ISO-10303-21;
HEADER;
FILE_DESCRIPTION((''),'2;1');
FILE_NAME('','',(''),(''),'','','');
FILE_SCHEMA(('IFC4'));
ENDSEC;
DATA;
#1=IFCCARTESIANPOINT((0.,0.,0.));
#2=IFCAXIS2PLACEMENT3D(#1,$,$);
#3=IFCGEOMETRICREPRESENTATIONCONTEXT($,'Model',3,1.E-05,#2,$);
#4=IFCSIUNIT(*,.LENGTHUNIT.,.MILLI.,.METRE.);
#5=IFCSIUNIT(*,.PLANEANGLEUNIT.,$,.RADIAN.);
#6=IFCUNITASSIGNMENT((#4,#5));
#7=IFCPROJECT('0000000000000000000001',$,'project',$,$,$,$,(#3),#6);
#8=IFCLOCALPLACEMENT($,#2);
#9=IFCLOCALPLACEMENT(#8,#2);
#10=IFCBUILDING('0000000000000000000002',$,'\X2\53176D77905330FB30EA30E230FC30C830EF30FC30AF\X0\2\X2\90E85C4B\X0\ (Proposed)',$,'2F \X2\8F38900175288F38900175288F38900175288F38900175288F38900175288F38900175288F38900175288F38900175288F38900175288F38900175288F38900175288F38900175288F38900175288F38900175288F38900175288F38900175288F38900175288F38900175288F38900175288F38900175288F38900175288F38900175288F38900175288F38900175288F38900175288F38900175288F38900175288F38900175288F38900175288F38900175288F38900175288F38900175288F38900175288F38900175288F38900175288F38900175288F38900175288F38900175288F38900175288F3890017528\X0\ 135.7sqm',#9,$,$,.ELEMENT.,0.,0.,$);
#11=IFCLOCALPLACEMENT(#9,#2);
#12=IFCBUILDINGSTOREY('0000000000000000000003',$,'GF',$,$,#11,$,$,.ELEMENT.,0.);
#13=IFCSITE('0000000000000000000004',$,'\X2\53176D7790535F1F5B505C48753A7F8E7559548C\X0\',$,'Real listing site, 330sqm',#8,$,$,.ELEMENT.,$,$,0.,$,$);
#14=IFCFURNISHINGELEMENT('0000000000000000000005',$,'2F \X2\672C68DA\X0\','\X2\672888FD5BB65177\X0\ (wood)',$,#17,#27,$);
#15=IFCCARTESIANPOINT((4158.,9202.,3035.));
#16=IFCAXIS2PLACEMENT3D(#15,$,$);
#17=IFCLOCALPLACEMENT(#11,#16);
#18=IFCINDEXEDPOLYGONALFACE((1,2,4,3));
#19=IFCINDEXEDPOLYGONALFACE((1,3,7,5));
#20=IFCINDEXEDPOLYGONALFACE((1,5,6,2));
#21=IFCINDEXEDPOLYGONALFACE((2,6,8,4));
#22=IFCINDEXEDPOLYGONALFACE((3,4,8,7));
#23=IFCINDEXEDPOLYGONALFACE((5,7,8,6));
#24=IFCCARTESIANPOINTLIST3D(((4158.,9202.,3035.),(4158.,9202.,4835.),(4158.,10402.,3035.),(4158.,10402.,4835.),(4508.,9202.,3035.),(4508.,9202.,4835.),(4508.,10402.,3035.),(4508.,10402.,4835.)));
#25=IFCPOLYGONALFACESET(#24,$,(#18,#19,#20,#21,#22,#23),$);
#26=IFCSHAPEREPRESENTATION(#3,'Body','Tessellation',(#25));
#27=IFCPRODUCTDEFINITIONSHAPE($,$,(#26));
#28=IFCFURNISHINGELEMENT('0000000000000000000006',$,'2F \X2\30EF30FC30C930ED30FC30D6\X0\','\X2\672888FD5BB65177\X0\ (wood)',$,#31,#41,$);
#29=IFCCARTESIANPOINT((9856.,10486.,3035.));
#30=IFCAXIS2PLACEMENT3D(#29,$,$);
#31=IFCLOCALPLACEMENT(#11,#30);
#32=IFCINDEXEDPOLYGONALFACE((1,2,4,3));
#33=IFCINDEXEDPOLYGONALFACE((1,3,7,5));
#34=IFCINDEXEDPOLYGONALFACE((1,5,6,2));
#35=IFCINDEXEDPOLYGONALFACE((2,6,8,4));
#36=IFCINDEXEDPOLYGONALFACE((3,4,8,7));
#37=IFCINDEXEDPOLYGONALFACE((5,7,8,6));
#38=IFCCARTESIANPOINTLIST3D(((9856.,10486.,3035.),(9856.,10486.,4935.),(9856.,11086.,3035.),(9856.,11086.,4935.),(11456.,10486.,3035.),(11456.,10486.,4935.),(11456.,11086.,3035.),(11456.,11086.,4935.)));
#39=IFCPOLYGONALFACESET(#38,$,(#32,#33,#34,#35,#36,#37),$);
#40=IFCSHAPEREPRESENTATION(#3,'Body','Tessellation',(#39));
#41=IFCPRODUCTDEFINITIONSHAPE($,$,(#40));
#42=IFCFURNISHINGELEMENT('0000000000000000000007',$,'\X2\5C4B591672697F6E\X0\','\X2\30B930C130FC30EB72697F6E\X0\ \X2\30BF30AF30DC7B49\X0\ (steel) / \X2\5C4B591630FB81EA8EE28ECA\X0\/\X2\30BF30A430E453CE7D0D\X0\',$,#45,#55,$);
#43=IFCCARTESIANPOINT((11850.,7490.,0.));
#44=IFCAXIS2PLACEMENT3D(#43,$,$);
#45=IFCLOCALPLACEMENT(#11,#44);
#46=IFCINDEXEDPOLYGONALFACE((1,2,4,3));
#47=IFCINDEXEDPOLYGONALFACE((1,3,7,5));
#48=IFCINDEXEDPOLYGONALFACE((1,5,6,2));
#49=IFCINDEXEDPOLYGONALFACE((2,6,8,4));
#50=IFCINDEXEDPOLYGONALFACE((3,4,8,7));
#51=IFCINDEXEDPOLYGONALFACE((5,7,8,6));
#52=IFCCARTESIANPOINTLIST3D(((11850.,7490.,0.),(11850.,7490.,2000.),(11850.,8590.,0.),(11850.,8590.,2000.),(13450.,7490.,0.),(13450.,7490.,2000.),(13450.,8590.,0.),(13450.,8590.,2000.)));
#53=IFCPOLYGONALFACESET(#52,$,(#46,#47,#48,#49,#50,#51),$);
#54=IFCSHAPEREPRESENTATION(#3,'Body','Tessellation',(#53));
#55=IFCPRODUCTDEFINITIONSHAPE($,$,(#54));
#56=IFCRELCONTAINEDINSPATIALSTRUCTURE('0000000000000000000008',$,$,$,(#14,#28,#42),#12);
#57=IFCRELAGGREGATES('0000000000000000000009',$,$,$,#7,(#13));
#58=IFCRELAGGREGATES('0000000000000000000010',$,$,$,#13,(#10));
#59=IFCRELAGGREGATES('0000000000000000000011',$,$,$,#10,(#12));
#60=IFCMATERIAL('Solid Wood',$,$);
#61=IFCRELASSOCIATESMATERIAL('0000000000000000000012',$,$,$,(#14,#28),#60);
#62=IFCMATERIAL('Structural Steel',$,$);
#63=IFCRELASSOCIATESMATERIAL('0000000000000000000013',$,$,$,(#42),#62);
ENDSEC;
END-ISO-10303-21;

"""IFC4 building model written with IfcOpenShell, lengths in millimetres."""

from ifc_helpers import new_model, si_unit, frame, frame_2d, origin, place, context, project, spatial, rectangle, extrude, material, element, save


model = new_model("IFC4")

# Units and contexts
model_context = context("Model", 3, precision=1e-05, world=origin())
ifc_project = project(units=[si_unit("LENGTHUNIT", "METRE", prefix="MILLI"), si_unit("PLANEANGLEUNIT", "RADIAN")], contexts=[model_context])

# Site, building, storey
site_placement = place(None, origin())
site = spatial("IfcSite", under=ifc_project, at=site_placement, Name="北海道弟子屈町美留和", ObjectType="Real listing site, 330sqm", CompositionType="ELEMENT", RefElevation=0.0)
building_placement = place(site_placement, origin())
building = spatial("IfcBuilding", under=site, at=building_placement, Name="北海道・リモートワーク2部屋 (Proposed)", ObjectType="2F 輸送用輸送用輸送用輸送用輸送用輸送用輸送用輸送用輸送用輸送用輸送用輸送用輸送用輸送用輸送用輸送用輸送用輸送用輸送用輸送用輸送用輸送用輸送用輸送用輸送用輸送用輸送用輸送用輸送用輸送用輸送用輸送用輸送用輸送用輸送用輸送用輸送用輸送用輸送用輸送用 135.7sqm", CompositionType="ELEMENT", ElevationOfRefHeight=0.0, ElevationOfTerrain=0.0)
storey_placement = place(building_placement, origin())
storey = spatial("IfcBuildingStorey", under=building, at=storey_placement, Name="GF", CompositionType="ELEMENT", Elevation=0.0)

# Shared definitions
ifc_material_1 = material(Name="Solid Wood")

# Shared definitions
ifc_material_2 = material(Name="Structural Steel")

# Furnishing elements
furnishing_1_placement = place(storey_placement, frame((4158.0, 9202.0, 3035.0)))
element("IfcFurnishingElement", 1, at=furnishing_1_placement, inside=storey, material=ifc_material_1, Name="2F 本棚", Description="木製家具 (wood)", context=model_context, shape_type="SweptSolid", body=[
    extrude(rectangle(XDim=350.0, YDim=1200.0, at=frame_2d((175.0, 600.0))), frame((4158.0, 9202.0, 3035.0)), (0.0, 0.0, 1.0), 1800.0),
])
furnishing_2_placement = place(storey_placement, frame((9856.0, 10486.0, 3035.0)))
element("IfcFurnishingElement", 2, at=furnishing_2_placement, inside=storey, material=ifc_material_1, Name="2F ワードローブ", Description="木製家具 (wood)", context=model_context, shape_type="SweptSolid", body=[
    extrude(rectangle(XDim=1600.0, YDim=600.0, at=frame_2d((800.0, 300.0))), frame((9856.0, 10486.0, 3035.0)), (0.0, 0.0, 1.0), 1900.0),
])
furnishing_3_placement = place(storey_placement, frame((11850.0, 7490.0, 0.0)))
element("IfcFurnishingElement", 3, at=furnishing_3_placement, inside=storey, material=ifc_material_2, Name="屋外物置", Description="スチール物置 タクボ等 (steel) / 屋外・自転車/タイヤ収納", context=model_context, shape_type="SweptSolid", body=[
    extrude(rectangle(XDim=1600.0, YDim=1100.0, at=frame_2d((800.0, 550.0))), frame((11850.0, 7490.0, 0.0)), (0.0, 0.0, 1.0), 2000.0),
])

save(model, "model.ifc")
